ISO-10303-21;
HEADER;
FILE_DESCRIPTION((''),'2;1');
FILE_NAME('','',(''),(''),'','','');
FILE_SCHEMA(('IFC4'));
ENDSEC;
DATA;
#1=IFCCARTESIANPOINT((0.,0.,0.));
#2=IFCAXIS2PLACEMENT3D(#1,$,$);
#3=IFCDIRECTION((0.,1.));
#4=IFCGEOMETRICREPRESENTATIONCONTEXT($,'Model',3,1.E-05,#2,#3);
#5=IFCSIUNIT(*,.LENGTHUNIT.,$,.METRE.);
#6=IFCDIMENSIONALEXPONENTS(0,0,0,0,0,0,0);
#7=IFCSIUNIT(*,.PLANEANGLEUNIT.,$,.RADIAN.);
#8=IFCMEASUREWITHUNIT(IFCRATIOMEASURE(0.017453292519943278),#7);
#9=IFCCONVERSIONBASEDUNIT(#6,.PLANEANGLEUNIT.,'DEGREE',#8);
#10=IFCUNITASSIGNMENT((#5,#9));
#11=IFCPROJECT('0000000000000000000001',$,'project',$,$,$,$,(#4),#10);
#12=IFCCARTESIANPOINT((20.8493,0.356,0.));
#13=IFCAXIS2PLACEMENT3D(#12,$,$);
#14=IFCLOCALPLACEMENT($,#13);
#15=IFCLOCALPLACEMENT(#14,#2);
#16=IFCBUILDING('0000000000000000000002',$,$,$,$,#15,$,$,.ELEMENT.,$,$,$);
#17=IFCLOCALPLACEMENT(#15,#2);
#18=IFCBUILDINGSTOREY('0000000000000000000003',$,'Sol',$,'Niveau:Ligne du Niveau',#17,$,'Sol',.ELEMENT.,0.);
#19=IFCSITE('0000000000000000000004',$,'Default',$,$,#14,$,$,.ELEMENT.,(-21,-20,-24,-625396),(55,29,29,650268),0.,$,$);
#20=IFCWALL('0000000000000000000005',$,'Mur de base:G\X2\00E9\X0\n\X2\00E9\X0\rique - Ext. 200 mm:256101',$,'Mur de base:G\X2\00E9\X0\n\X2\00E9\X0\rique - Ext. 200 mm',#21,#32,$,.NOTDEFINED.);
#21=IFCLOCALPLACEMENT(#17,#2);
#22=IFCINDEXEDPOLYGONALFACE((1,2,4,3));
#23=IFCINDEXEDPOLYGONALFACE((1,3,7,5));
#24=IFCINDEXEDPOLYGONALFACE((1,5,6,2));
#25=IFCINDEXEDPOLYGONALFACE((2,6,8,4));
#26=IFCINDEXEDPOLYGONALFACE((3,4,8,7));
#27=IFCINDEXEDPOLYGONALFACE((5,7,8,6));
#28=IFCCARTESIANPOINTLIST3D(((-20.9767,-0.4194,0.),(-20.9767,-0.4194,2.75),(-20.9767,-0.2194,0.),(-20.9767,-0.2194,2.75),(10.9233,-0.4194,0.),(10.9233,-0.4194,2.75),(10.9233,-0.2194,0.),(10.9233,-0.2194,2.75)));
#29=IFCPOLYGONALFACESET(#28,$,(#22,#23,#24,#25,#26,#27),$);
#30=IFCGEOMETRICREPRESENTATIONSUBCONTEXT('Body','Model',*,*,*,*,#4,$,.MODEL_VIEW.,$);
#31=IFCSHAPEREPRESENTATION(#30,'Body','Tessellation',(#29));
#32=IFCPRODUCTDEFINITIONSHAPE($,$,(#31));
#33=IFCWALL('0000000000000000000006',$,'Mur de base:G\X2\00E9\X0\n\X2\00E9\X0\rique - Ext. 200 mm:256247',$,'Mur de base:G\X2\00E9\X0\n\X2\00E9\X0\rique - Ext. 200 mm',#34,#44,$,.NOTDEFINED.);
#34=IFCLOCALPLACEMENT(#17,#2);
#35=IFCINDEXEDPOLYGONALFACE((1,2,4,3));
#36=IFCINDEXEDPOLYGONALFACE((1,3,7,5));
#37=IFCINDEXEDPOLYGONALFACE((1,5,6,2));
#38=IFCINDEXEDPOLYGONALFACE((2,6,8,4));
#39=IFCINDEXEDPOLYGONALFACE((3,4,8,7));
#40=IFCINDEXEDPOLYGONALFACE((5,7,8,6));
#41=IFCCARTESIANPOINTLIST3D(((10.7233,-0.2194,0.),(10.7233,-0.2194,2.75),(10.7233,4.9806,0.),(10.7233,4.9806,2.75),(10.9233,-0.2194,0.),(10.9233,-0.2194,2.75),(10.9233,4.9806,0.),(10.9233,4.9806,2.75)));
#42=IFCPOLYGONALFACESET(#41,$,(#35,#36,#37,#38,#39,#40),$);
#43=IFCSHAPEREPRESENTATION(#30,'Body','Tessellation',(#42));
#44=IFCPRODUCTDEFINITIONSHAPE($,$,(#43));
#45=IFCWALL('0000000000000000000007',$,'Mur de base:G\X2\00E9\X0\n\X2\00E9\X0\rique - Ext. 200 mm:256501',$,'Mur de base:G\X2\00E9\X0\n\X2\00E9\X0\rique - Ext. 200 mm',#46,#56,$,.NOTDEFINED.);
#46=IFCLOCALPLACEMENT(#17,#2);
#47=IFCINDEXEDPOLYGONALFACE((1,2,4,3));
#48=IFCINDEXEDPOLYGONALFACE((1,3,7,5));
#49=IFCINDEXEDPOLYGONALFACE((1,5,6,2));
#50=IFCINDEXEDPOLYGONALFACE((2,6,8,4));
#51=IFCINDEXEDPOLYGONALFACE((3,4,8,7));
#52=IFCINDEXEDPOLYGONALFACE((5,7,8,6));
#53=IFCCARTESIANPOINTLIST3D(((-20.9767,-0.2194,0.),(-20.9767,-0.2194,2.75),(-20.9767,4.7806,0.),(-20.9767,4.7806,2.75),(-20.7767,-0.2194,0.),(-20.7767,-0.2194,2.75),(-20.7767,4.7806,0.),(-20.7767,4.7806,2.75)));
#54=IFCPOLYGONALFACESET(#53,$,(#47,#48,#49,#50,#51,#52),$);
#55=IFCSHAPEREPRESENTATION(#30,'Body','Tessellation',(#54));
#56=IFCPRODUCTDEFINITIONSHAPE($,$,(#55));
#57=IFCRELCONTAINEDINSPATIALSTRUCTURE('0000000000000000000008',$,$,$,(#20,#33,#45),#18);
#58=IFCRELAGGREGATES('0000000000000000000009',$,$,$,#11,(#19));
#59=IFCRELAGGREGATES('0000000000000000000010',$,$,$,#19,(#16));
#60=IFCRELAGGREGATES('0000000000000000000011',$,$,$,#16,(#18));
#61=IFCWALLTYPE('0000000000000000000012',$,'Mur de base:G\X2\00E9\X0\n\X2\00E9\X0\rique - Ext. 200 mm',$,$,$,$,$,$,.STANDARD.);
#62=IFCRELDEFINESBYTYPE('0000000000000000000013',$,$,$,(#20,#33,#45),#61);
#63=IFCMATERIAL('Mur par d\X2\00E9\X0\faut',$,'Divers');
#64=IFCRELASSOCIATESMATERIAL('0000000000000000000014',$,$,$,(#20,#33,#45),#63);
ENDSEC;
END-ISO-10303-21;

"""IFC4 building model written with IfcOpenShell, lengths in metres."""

from ifc_helpers import new_model, entity, si_unit, converted_unit, direction, frame, origin, place, context, subcontext, project, spatial, indexed_curve, outline, extrude, material, type_object, element, save


model = new_model("IFC4")

# Units and contexts
model_context = context("Model", 3, precision=1e-05, world=origin(), true_north=direction((0.0, 1.0)))
body_context = subcontext(model_context, "Body", "Model", "MODEL_VIEW")
ifc_project = project(units=[si_unit("LENGTHUNIT", "METRE"), converted_unit("PLANEANGLEUNIT", "DEGREE", entity("IfcRatioMeasure", 0.017453292519943278), si_unit("PLANEANGLEUNIT", "RADIAN"), dimensions=[0, 0, 0, 0, 0, 0, 0])], contexts=[model_context])

# Site, building, storey
site_placement = place(None, frame((20.8493, 0.356, 0.0)))
site = spatial("IfcSite", under=ifc_project, at=site_placement, Name="Default", CompositionType="ELEMENT", RefLatitude=(-21, -20, -24, -625396), RefLongitude=(55, 29, 29, 650268), RefElevation=0.0)
building_placement = place(site_placement, origin())
building = spatial("IfcBuilding", under=site, at=building_placement, CompositionType="ELEMENT")
storey_placement = place(building_placement, origin())
storey = spatial("IfcBuildingStorey", under=building, at=storey_placement, Name="Sol", ObjectType="Niveau:Ligne du Niveau", LongName="Sol", CompositionType="ELEMENT", Elevation=0.0)

# Walls
ifc_material = material(Name="Mur par défaut", Category="Divers")
wall_type = type_object("IfcWallType", Name="Mur de base:Générique - Ext. 200 mm", PredefinedType="STANDARD")
wall_1_placement = place(storey_placement, frame((-20.9767, -0.3194, 0.0)))
element("IfcWall", 1, at=wall_1_placement, inside=storey, type_object=wall_type, material=ifc_material, Name="Mur de base:Générique - Ext. 200 mm:256101", ObjectType="Mur de base:Générique - Ext. 200 mm", PredefinedType="NOTDEFINED", context=body_context, shape_type="SweptSolid", body=[
    extrude(outline(indexed_curve([(31.9, 0.1), (0.0, 0.1), (0.0, -0.1), (31.9, -0.1), (31.9, 0.1)], self_intersect=False)), origin(), (0.0, 0.0, 1.0), 2.75),
])
wall_2_placement = place(storey_placement, frame((10.8233, -0.2194, 0.0), z_axis=(0.0, 0.0, 1.0), x_axis=(0.0, 1.0, 0.0)))
element("IfcWall", 2, at=wall_2_placement, inside=storey, type_object=wall_type, material=ifc_material, Name="Mur de base:Générique - Ext. 200 mm:256247", ObjectType="Mur de base:Générique - Ext. 200 mm", PredefinedType="NOTDEFINED", context=body_context, shape_type="SweptSolid", body=[
    extrude(outline(indexed_curve([(5.2, 0.1), (0.0, 0.1), (0.0, -0.1), (5.2, -0.1), (5.2, 0.1)], self_intersect=False)), origin(), (0.0, 0.0, 1.0), 2.75),
])
wall_3_placement = place(storey_placement, frame((-20.8767, 4.7806, 0.0), z_axis=(0.0, 0.0, 1.0), x_axis=(0.0, -1.0, 0.0)))
element("IfcWall", 3, at=wall_3_placement, inside=storey, type_object=wall_type, material=ifc_material, Name="Mur de base:Générique - Ext. 200 mm:256501", ObjectType="Mur de base:Générique - Ext. 200 mm", PredefinedType="NOTDEFINED", context=body_context, shape_type="SweptSolid", body=[
    extrude(outline(indexed_curve([(5.0, 0.1), (0.0, 0.1), (0.0, -0.1), (5.0, -0.1), (5.0, 0.1)], self_intersect=False)), origin(), (0.0, 0.0, 1.0), 2.75),
])

save(model, "model.ifc")
